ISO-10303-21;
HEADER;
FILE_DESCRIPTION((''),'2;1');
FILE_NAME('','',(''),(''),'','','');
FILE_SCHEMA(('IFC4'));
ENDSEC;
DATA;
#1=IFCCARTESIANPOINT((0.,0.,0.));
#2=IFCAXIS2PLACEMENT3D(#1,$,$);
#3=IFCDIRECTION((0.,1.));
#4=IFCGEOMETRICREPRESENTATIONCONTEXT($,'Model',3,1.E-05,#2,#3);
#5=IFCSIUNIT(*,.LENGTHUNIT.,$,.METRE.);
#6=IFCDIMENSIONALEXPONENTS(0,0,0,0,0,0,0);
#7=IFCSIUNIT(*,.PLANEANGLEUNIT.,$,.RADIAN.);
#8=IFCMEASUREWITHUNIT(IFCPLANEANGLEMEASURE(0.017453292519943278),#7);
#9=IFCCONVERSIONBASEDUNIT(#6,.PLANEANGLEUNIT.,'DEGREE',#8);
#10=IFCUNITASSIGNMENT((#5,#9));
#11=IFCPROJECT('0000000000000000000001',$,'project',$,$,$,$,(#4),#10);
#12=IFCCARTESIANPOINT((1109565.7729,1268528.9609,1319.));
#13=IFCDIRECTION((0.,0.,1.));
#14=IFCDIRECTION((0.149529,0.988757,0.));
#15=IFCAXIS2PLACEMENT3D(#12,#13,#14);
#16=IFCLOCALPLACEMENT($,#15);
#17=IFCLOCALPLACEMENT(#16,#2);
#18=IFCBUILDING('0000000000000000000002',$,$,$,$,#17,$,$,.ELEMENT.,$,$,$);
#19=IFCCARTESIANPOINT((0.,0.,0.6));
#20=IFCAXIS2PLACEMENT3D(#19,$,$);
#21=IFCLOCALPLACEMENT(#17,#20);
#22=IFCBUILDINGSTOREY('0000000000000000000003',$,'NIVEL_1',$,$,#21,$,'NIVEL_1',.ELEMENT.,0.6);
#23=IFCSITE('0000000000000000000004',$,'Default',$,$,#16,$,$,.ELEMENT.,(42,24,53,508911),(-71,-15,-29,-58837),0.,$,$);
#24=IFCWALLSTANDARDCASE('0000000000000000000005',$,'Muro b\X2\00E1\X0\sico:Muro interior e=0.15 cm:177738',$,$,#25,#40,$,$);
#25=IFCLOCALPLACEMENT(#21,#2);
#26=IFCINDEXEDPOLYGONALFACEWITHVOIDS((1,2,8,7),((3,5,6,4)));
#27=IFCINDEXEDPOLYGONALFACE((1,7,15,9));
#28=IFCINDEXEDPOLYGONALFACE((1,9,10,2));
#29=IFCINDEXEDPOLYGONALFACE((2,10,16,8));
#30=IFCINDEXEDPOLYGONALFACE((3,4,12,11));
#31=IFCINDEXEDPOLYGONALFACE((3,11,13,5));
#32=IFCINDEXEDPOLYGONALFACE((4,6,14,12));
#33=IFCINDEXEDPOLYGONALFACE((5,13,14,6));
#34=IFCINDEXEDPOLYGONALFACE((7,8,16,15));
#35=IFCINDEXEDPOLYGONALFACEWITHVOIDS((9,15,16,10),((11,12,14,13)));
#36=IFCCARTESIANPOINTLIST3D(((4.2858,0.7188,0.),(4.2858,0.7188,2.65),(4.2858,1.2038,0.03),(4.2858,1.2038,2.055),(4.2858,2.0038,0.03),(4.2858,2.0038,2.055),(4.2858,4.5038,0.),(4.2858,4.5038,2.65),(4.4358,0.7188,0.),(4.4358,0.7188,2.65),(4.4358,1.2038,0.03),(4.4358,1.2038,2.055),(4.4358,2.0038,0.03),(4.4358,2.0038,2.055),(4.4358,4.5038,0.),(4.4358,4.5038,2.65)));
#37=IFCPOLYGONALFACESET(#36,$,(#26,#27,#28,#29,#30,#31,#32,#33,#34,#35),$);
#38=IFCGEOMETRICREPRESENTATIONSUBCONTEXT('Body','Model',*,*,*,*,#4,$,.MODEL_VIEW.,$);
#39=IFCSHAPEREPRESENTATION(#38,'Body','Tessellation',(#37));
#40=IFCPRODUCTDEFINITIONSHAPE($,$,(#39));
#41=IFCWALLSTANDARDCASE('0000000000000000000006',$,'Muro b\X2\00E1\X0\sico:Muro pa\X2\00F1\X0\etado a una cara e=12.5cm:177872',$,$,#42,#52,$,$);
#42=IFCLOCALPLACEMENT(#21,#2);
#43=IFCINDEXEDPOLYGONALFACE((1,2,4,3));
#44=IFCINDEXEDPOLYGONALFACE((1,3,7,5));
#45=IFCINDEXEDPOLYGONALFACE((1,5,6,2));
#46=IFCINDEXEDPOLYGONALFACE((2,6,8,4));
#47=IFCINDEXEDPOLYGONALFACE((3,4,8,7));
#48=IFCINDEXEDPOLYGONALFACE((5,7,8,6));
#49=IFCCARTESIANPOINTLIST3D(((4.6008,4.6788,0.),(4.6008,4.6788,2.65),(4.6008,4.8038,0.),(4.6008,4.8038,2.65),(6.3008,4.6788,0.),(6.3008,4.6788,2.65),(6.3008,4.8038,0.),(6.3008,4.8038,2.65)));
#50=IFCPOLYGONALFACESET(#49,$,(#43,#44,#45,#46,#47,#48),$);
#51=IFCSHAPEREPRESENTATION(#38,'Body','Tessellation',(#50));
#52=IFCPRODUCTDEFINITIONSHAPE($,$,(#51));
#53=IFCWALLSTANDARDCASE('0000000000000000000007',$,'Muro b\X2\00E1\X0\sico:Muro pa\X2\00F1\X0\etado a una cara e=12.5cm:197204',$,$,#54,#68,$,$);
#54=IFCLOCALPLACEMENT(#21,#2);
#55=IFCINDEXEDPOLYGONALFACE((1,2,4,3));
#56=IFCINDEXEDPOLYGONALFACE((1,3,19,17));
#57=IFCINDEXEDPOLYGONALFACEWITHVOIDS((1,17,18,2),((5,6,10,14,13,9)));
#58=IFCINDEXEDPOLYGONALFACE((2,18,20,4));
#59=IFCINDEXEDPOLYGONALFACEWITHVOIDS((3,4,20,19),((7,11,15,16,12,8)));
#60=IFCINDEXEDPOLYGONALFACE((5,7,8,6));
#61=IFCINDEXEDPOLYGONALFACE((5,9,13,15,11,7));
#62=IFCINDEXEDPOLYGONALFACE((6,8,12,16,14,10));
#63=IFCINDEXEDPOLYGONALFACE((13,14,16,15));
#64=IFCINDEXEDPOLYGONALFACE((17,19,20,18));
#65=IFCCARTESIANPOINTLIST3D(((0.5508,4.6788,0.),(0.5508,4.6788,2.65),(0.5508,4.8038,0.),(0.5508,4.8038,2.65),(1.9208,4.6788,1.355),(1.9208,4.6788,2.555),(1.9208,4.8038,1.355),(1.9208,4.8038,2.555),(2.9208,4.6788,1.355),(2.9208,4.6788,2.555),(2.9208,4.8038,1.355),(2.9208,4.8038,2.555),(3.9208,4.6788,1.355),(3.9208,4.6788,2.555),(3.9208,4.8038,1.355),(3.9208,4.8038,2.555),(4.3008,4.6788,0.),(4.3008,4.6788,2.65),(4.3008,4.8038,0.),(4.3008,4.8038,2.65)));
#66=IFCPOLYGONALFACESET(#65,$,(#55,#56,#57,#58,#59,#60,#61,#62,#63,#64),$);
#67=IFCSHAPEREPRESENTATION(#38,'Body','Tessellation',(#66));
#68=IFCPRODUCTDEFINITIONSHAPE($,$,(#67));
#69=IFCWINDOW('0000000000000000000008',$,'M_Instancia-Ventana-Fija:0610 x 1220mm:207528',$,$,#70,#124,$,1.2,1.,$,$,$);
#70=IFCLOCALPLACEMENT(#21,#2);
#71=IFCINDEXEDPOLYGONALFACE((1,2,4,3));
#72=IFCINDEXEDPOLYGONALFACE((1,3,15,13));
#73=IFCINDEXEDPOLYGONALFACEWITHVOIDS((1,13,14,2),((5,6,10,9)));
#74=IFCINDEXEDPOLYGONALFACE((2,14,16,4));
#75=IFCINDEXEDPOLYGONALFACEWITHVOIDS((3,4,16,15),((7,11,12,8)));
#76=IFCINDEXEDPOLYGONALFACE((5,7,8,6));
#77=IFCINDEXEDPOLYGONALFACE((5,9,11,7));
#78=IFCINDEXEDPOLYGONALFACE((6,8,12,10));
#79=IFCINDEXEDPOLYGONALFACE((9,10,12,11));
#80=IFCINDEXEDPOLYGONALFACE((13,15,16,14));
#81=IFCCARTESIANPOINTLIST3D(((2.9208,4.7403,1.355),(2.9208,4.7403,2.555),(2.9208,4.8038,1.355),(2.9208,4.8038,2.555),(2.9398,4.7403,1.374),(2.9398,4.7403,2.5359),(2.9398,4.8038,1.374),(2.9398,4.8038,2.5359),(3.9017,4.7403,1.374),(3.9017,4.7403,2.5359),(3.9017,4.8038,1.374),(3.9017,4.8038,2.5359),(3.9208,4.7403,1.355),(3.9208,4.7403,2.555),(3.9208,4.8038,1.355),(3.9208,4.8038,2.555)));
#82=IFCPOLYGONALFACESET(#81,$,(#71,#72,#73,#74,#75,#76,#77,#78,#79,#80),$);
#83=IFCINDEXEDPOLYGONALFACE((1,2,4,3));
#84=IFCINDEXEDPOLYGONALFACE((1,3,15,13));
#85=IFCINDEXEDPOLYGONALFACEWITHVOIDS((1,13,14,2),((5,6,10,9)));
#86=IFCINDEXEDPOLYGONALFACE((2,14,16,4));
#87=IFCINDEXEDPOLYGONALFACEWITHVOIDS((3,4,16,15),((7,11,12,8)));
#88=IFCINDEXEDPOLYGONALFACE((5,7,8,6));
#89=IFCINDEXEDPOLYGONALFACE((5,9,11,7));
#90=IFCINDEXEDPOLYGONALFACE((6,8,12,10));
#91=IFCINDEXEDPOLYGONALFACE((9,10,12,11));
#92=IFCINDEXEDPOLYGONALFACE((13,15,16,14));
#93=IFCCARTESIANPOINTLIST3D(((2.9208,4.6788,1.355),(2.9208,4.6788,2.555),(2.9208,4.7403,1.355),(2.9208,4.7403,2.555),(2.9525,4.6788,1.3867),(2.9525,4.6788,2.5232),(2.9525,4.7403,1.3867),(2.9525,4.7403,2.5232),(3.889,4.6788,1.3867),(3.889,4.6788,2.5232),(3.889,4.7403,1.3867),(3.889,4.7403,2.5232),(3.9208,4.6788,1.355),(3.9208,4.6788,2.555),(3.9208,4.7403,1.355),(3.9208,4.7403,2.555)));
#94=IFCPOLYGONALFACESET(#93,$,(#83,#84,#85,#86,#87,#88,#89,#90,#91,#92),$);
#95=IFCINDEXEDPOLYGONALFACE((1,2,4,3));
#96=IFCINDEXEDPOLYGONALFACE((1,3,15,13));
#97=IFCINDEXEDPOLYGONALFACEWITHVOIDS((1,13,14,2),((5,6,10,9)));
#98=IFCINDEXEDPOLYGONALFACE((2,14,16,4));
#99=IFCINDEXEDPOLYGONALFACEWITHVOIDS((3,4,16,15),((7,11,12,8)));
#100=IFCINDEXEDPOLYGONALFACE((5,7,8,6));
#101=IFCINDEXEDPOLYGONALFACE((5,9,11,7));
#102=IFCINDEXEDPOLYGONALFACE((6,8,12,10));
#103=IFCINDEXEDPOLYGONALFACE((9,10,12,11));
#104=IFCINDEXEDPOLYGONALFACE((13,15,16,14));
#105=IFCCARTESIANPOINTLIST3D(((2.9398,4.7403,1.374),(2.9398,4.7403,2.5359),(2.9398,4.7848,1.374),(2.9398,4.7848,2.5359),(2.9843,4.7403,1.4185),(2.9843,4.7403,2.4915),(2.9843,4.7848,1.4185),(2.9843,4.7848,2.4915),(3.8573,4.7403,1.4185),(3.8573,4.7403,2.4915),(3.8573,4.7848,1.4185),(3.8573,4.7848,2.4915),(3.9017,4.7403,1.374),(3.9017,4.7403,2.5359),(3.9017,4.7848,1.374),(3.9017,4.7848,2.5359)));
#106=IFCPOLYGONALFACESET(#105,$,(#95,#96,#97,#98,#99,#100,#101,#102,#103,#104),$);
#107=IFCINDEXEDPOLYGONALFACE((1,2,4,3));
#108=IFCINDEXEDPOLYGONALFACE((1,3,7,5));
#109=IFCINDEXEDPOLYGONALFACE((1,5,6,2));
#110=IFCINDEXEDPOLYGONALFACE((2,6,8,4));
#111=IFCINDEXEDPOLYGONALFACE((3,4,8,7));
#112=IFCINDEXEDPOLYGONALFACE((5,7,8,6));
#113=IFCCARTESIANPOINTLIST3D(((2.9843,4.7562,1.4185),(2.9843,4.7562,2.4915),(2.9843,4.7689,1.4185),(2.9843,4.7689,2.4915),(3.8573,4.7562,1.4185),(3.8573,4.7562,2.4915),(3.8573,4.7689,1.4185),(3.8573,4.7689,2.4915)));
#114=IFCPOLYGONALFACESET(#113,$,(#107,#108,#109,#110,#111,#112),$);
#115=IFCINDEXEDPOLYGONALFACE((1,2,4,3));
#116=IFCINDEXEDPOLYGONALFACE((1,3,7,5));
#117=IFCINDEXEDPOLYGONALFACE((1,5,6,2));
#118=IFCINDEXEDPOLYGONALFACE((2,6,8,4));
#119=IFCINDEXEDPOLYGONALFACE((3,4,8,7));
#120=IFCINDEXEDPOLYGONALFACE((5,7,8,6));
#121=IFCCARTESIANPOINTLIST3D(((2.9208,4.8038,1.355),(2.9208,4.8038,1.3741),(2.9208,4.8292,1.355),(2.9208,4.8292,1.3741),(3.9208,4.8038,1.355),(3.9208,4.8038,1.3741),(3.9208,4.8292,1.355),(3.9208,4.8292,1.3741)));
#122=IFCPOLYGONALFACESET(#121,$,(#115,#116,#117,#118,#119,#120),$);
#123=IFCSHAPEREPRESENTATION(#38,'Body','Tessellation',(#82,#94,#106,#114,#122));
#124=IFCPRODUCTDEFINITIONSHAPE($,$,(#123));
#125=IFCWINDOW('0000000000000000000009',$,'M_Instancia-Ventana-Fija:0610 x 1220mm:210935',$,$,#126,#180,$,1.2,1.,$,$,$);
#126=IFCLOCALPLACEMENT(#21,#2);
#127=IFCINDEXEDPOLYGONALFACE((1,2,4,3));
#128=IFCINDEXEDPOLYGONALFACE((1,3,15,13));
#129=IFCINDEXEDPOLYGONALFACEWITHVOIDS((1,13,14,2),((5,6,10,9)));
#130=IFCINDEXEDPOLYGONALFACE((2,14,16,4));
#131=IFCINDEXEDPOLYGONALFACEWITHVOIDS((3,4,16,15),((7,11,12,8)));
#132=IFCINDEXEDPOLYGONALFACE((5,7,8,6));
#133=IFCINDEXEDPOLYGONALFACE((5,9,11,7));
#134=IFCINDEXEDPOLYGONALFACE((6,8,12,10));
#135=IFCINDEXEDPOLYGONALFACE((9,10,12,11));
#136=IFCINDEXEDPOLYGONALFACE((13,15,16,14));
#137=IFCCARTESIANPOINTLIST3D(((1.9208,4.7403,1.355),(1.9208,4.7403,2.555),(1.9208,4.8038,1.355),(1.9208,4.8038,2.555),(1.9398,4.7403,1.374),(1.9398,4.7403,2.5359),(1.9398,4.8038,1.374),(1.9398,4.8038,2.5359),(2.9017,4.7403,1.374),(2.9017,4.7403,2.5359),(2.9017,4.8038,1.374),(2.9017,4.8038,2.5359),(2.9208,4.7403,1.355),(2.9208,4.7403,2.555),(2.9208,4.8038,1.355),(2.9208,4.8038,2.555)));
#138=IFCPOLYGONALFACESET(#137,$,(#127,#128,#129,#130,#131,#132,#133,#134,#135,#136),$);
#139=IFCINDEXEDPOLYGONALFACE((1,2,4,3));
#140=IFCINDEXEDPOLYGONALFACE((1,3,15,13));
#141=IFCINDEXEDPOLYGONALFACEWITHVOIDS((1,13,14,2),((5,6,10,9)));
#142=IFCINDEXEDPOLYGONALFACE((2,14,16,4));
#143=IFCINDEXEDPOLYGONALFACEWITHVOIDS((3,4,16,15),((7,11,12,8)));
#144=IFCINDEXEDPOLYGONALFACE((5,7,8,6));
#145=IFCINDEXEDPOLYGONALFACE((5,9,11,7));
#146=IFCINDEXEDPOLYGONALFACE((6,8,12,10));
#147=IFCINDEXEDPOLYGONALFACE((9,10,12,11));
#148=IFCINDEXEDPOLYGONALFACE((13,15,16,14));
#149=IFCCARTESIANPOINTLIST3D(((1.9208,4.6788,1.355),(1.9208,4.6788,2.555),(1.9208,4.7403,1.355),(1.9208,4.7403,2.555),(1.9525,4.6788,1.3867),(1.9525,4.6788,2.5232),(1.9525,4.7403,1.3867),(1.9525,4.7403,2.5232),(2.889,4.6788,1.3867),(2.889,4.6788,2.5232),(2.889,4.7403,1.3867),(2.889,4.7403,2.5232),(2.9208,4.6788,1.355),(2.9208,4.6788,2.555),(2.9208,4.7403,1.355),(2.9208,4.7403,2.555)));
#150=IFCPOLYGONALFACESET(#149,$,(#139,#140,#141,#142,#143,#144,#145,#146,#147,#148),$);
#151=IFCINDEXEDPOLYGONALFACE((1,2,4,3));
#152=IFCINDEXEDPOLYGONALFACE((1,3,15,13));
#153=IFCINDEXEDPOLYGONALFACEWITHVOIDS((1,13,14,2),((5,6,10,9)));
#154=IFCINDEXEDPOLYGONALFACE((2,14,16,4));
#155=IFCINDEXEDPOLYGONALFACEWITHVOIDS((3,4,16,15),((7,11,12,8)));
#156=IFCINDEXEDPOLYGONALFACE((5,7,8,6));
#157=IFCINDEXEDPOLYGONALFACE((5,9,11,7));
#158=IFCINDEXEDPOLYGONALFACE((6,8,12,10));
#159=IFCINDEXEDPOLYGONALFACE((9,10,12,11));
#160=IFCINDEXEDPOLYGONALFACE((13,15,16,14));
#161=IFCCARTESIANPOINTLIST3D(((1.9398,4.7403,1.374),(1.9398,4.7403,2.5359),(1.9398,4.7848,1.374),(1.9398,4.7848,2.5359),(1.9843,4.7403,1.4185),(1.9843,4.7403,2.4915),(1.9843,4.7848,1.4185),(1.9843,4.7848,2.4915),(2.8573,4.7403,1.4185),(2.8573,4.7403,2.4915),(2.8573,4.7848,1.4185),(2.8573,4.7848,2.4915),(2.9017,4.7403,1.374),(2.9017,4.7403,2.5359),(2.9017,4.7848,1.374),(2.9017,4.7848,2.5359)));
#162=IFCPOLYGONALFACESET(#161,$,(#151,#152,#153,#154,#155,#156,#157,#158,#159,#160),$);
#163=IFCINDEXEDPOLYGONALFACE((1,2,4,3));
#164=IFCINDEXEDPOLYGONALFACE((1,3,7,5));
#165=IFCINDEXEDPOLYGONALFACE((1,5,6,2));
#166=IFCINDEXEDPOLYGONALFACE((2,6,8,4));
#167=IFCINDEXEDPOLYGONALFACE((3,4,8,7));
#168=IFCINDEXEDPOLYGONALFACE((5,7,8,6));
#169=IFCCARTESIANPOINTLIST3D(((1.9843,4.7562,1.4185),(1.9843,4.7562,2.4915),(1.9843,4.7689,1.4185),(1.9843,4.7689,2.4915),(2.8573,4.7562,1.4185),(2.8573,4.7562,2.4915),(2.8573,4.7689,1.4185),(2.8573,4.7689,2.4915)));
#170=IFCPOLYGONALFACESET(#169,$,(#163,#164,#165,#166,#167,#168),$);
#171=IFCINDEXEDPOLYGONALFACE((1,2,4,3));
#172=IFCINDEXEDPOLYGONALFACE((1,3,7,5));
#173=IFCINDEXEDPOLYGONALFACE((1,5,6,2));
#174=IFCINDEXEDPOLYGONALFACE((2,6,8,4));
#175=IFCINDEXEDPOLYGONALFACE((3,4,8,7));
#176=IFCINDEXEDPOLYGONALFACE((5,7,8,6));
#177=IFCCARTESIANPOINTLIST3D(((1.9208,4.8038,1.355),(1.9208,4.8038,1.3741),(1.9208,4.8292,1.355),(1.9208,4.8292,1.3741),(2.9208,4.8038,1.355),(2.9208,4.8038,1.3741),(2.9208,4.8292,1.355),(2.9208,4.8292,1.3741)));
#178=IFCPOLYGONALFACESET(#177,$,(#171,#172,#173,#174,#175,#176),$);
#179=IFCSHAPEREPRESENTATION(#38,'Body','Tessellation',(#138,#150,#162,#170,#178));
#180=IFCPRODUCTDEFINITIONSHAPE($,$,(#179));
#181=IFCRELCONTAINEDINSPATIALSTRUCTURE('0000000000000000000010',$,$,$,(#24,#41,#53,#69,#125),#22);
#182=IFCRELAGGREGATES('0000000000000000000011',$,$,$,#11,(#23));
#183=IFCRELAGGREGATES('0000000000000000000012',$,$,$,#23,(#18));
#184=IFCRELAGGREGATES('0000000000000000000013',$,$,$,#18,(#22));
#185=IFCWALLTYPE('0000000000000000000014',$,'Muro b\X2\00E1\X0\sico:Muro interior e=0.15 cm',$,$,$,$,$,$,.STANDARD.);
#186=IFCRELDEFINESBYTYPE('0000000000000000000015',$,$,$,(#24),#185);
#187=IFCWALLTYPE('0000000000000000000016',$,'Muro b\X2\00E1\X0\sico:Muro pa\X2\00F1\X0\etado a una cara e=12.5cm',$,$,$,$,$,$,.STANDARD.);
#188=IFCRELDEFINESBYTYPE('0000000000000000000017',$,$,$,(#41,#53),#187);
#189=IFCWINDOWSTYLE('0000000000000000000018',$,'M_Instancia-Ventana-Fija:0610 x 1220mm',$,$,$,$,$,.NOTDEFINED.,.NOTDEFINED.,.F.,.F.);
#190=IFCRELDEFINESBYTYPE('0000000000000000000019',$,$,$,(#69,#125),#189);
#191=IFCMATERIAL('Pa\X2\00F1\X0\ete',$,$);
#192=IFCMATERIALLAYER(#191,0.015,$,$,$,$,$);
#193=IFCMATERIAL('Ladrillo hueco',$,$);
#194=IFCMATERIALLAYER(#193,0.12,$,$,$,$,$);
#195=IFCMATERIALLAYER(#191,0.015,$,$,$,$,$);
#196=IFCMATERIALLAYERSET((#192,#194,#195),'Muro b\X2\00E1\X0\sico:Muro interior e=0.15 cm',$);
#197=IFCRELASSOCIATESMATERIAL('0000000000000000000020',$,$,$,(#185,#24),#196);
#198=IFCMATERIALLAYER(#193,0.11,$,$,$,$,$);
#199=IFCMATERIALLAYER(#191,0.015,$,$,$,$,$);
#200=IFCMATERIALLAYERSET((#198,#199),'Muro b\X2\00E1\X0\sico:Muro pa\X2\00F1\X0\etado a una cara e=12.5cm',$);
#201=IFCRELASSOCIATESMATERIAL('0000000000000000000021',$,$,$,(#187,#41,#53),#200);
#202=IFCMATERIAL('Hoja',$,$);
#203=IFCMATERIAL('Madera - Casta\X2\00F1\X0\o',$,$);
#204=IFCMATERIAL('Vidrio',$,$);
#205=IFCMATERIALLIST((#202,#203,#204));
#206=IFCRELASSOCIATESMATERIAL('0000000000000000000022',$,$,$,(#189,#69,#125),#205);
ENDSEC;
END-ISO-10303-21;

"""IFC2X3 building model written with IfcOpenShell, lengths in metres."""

from ifc_helpers import new_model, entity, si_unit, converted_unit, direction, frame, frame_2d, origin, origin_2d_with_axis, place, context, subcontext, project, spatial, polyline, rectangle, outline, extrude, source, transform, mapped, material, material_list, layer, layer_set, layer_usage, type_object, type_shapes, element, fill, save


model = new_model("IFC2X3")

# Units and contexts
model_context = context("Model", 3, precision=1e-05, world=origin(), true_north=direction((0.0, 1.0)))
body_context = subcontext(model_context, "Body", "Model", "MODEL_VIEW")
ifc_project = project(units=[si_unit("LENGTHUNIT", "METRE"), converted_unit("PLANEANGLEUNIT", "DEGREE", entity("IfcPlaneAngleMeasure", 0.017453292519943278), si_unit("PLANEANGLEUNIT", "RADIAN"), dimensions=[0, 0, 0, 0, 0, 0, 0])], contexts=[model_context])

# Site, building, storey
site_placement = place(None, frame((1109565.7729, 1268528.9609, 1319.0), z_axis=(0.0, 0.0, 1.0), x_axis=(0.149529, 0.988757, 0.0)))
site = spatial("IfcSite", under=ifc_project, at=site_placement, Name="Default", CompositionType="ELEMENT", RefLatitude=(42, 24, 53, 508911), RefLongitude=(-71, -15, -29, -58837), RefElevation=0.0)
building_placement = place(site_placement, origin())
building = spatial("IfcBuilding", under=site, at=building_placement, CompositionType="ELEMENT")
storey_placement = place(building_placement, frame((0.0, 0.0, 0.6)))
storey = spatial("IfcBuildingStorey", under=building, at=storey_placement, Name="NIVEL_1", LongName="NIVEL_1", CompositionType="ELEMENT", Elevation=0.6)

# Wall, opening
ifc_material_1 = material(Name="Pañete")
ifc_layer_1 = layer(ifc_material_1, 0.015)
ifc_material_2 = material(Name="Ladrillo hueco")
ifc_layer_2 = layer(ifc_material_2, 0.12)
ifc_layer_3 = layer(ifc_material_1, 0.015)
ifc_layer_set_1 = layer_set([ifc_layer_1, ifc_layer_2, ifc_layer_3], Name="Muro básico:Muro interior e=0.15 cm")
ifc_layer_usage_1 = layer_usage(ifc_layer_set_1, "AXIS2", "POSITIVE", -0.075)
wall_type_1 = type_object("IfcWallType", Name="Muro básico:Muro interior e=0.15 cm", PredefinedType="STANDARD", material=ifc_layer_set_1)
wall_1_placement = place(storey_placement, frame((4.3608, 4.5038, 0.0), z_axis=(0.0, 0.0, 1.0), x_axis=(0.0, -1.0, 0.0)))
wall_1 = element("IfcWallStandardCase", 1, at=wall_1_placement, inside=storey, type_object=wall_type_1, material=ifc_layer_usage_1, Name="Muro básico:Muro interior e=0.15 cm:177738", context=body_context, shape_type="SweptSolid", body=[
    extrude(rectangle(XDim=3.785, YDim=0.15, at=frame_2d((1.8925, 0.0), x_axis=(-1.0, 0.0))), origin(), (0.0, 0.0, 1.0), 2.65),
])
opening_1_placement = place(wall_1_placement, frame((2.5, -0.075, 0.03)))
element("IfcOpeningElement", 2, at=opening_1_placement, cuts=wall_1, ObjectType="Opening", context=body_context, shape_type="SweptSolid", body=[
    extrude(rectangle(XDim=2.025, YDim=0.8, at=frame_2d((1.0125, 0.4), x_axis=(1.0, 0.0))), frame((0.0, 0.0, 0.0), z_axis=(0.0, 1.0, 0.0), x_axis=(0.0, 0.0, 1.0)), (0.0, 0.0, 1.0), 0.15),
])

# Wall
ifc_layer_4 = layer(ifc_material_2, 0.11)
ifc_layer_5 = layer(ifc_material_1, 0.015)
ifc_layer_set_2 = layer_set([ifc_layer_4, ifc_layer_5], Name="Muro básico:Muro pañetado a una cara e=12.5cm")
ifc_layer_usage_2 = layer_usage(ifc_layer_set_2, "AXIS2", "NEGATIVE", 0.0625)
wall_type_2 = type_object("IfcWallType", Name="Muro básico:Muro pañetado a una cara e=12.5cm", PredefinedType="STANDARD", material=ifc_layer_set_2)
wall_2_placement = place(storey_placement, frame((4.6008, 4.7413, 0.0)))
element("IfcWallStandardCase", 3, at=wall_2_placement, inside=storey, type_object=wall_type_2, material=ifc_layer_usage_2, Name="Muro básico:Muro pañetado a una cara e=12.5cm:177872", context=body_context, shape_type="SweptSolid", body=[
    extrude(rectangle(XDim=1.7, YDim=0.125, at=frame_2d((0.85, 0.0), x_axis=(-1.0, 0.0))), origin(), (0.0, 0.0, 1.0), 2.65),
])

# Wall, openings, windows
ifc_material_3 = material(Name="Hoja")
ifc_material_4 = material(Name="Madera - Castaño")
ifc_material_5 = material(Name="Vidrio")
ifc_material_list = material_list([ifc_material_3, ifc_material_4, ifc_material_5])
ifc_layer_usage_3 = layer_usage(ifc_layer_set_2, "AXIS2", "POSITIVE", -0.0625)
wall_3_placement = place(storey_placement, frame((4.3008, 4.7413, 0.0), z_axis=(0.0, 0.0, 1.0), x_axis=(-1.0, 0.0, 0.0)))
wall_3 = element("IfcWallStandardCase", 4, at=wall_3_placement, inside=storey, type_object=wall_type_2, material=ifc_layer_usage_3, Name="Muro básico:Muro pañetado a una cara e=12.5cm:197204", context=body_context, shape_type="SweptSolid", body=[
    extrude(rectangle(XDim=3.75, YDim=0.125, at=frame_2d((1.875, 0.0), x_axis=(-1.0, 0.0))), origin(), (0.0, 0.0, 1.0), 2.65),
])
opening_2_placement = place(wall_3_placement, frame((1.38, 0.0625, 1.355)))
opening_2 = element("IfcOpeningElement", 5, at=opening_2_placement, cuts=wall_3, ObjectType="Opening", context=body_context, shape_type="SweptSolid", body=[
    extrude(rectangle(XDim=1.2, YDim=1.0, at=frame_2d((0.6, 0.5), x_axis=(-1.0, 0.0))), frame((0.0, 0.0, 0.0), z_axis=(0.0, -1.0, 0.0), x_axis=(0.0, 0.0, 1.0)), (0.0, 0.0, 1.0), 0.125),
])
opening_3_placement = place(wall_3_placement, frame((2.38, 0.0625, 1.355)))
opening_3 = element("IfcOpeningElement", 6, at=opening_3_placement, cuts=wall_3, ObjectType="Opening", context=body_context, shape_type="SweptSolid", body=[
    extrude(rectangle(XDim=1.2, YDim=1.0, at=frame_2d((0.6, 0.5), x_axis=(-1.0, 0.0))), frame((0.0, 0.0, 0.0), z_axis=(0.0, -1.0, 0.0), x_axis=(0.0, 0.0, 1.0)), (0.0, 0.0, 1.0), 0.125),
])
window_style_1 = type_object("IfcWindowStyle", Name="M_Instancia-Ventana-Fija:0610 x 1220mm", ConstructionType="NOTDEFINED", OperationType="NOTDEFINED", ParameterTakesPrecedence=False, Sizeable=False, material=ifc_material_list)
shared_shape_1 = source(origin(), body_context, "Body", "SweptSolid", [
    extrude(outline(polyline([(-0.6, -0.5), (0.6, -0.5), (0.6, 0.5), (-0.6, 0.5), (-0.6, -0.5)]), holes=[polyline([(-0.5809, -0.4809), (-0.5809, 0.481), (0.581, 0.481), (0.581, -0.4809), (-0.5809, -0.4809)])]), frame((0.5, 0.0616, 0.6), z_axis=(0.0, 1.0, 0.0), x_axis=(0.0, 0.0, -1.0)), (0.0, 0.0, 1.0), 0.0635),
    extrude(outline(polyline([(-0.5, -0.6), (0.5, -0.6), (0.5, 0.6), (-0.5, 0.6), (-0.5, -0.6)]), holes=[polyline([(-0.4683, -0.5682), (-0.4683, 0.5683), (0.4682, 0.5683), (0.4682, -0.5682), (-0.4683, -0.5682)])]), frame((0.5, 0.0, 0.6), z_axis=(0.0, 1.0, 0.0), x_axis=(1.0, 0.0, 0.0)), (0.0, 0.0, 1.0), 0.0616),
    extrude(outline(polyline([(-0.4809, -0.581), (0.4809, -0.581), (0.4809, 0.581), (-0.4809, 0.581), (-0.4809, -0.581)]), holes=[polyline([(-0.4365, -0.5365), (-0.4365, 0.5365), (0.4365, 0.5365), (0.4365, -0.5365), (-0.4365, -0.5365)])]), frame((0.5, 0.0616, 0.6), z_axis=(0.0, 1.0, 0.0), x_axis=(1.0, 0.0, 0.0)), (0.0, 0.0, 1.0), 0.0444),
    extrude(rectangle(XDim=0.0127, YDim=0.873, at=origin_2d_with_axis()), frame((0.5, 0.0838, 0.0635), z_axis=(0.0, 0.0, 1.0), x_axis=(0.0, 1.0, 0.0)), (0.0, 0.0, 1.0), 1.073),
    extrude(rectangle(XDim=0.0254, YDim=1.0, at=origin_2d_with_axis()), frame((0.5, 0.1377, 0.0), z_axis=(0.0, 0.0, 1.0), x_axis=(0.0, -1.0, 0.0)), (0.0, 0.0, 1.0), 0.019),
])
type_shapes(window_style_1, [shared_shape_1])
window_1_placement = place(opening_2_placement, frame((0.0, 0.0, 0.0), z_axis=(0.0, 0.0, 1.0), x_axis=(-1.0, 0.0, 0.0)))
window_1 = element("IfcWindow", 7, at=window_1_placement, inside=storey, type_object=window_style_1, material=ifc_material_list, Name="M_Instancia-Ventana-Fija:0610 x 1220mm:207528", OverallHeight=1.2, OverallWidth=1.0, context=body_context, shape_type="MappedRepresentation", body=[
    mapped(shared_shape_1, transform((0.0, 0.0, 0.0), scale=1.0)),
])
fill(opening_2, window_1)
window_2_placement = place(opening_3_placement, frame((0.0, 0.0, 0.0), z_axis=(0.0, 0.0, 1.0), x_axis=(-1.0, 0.0, 0.0)))
window_2 = element("IfcWindow", 8, at=window_2_placement, inside=storey, type_object=window_style_1, material=ifc_material_list, Name="M_Instancia-Ventana-Fija:0610 x 1220mm:210935", OverallHeight=1.2, OverallWidth=1.0, context=body_context, shape_type="MappedRepresentation", body=[
    mapped(shared_shape_1, transform((0.0, 0.0, 0.0), scale=1.0)),
])
fill(opening_3, window_2)

save(model, "model.ifc")
